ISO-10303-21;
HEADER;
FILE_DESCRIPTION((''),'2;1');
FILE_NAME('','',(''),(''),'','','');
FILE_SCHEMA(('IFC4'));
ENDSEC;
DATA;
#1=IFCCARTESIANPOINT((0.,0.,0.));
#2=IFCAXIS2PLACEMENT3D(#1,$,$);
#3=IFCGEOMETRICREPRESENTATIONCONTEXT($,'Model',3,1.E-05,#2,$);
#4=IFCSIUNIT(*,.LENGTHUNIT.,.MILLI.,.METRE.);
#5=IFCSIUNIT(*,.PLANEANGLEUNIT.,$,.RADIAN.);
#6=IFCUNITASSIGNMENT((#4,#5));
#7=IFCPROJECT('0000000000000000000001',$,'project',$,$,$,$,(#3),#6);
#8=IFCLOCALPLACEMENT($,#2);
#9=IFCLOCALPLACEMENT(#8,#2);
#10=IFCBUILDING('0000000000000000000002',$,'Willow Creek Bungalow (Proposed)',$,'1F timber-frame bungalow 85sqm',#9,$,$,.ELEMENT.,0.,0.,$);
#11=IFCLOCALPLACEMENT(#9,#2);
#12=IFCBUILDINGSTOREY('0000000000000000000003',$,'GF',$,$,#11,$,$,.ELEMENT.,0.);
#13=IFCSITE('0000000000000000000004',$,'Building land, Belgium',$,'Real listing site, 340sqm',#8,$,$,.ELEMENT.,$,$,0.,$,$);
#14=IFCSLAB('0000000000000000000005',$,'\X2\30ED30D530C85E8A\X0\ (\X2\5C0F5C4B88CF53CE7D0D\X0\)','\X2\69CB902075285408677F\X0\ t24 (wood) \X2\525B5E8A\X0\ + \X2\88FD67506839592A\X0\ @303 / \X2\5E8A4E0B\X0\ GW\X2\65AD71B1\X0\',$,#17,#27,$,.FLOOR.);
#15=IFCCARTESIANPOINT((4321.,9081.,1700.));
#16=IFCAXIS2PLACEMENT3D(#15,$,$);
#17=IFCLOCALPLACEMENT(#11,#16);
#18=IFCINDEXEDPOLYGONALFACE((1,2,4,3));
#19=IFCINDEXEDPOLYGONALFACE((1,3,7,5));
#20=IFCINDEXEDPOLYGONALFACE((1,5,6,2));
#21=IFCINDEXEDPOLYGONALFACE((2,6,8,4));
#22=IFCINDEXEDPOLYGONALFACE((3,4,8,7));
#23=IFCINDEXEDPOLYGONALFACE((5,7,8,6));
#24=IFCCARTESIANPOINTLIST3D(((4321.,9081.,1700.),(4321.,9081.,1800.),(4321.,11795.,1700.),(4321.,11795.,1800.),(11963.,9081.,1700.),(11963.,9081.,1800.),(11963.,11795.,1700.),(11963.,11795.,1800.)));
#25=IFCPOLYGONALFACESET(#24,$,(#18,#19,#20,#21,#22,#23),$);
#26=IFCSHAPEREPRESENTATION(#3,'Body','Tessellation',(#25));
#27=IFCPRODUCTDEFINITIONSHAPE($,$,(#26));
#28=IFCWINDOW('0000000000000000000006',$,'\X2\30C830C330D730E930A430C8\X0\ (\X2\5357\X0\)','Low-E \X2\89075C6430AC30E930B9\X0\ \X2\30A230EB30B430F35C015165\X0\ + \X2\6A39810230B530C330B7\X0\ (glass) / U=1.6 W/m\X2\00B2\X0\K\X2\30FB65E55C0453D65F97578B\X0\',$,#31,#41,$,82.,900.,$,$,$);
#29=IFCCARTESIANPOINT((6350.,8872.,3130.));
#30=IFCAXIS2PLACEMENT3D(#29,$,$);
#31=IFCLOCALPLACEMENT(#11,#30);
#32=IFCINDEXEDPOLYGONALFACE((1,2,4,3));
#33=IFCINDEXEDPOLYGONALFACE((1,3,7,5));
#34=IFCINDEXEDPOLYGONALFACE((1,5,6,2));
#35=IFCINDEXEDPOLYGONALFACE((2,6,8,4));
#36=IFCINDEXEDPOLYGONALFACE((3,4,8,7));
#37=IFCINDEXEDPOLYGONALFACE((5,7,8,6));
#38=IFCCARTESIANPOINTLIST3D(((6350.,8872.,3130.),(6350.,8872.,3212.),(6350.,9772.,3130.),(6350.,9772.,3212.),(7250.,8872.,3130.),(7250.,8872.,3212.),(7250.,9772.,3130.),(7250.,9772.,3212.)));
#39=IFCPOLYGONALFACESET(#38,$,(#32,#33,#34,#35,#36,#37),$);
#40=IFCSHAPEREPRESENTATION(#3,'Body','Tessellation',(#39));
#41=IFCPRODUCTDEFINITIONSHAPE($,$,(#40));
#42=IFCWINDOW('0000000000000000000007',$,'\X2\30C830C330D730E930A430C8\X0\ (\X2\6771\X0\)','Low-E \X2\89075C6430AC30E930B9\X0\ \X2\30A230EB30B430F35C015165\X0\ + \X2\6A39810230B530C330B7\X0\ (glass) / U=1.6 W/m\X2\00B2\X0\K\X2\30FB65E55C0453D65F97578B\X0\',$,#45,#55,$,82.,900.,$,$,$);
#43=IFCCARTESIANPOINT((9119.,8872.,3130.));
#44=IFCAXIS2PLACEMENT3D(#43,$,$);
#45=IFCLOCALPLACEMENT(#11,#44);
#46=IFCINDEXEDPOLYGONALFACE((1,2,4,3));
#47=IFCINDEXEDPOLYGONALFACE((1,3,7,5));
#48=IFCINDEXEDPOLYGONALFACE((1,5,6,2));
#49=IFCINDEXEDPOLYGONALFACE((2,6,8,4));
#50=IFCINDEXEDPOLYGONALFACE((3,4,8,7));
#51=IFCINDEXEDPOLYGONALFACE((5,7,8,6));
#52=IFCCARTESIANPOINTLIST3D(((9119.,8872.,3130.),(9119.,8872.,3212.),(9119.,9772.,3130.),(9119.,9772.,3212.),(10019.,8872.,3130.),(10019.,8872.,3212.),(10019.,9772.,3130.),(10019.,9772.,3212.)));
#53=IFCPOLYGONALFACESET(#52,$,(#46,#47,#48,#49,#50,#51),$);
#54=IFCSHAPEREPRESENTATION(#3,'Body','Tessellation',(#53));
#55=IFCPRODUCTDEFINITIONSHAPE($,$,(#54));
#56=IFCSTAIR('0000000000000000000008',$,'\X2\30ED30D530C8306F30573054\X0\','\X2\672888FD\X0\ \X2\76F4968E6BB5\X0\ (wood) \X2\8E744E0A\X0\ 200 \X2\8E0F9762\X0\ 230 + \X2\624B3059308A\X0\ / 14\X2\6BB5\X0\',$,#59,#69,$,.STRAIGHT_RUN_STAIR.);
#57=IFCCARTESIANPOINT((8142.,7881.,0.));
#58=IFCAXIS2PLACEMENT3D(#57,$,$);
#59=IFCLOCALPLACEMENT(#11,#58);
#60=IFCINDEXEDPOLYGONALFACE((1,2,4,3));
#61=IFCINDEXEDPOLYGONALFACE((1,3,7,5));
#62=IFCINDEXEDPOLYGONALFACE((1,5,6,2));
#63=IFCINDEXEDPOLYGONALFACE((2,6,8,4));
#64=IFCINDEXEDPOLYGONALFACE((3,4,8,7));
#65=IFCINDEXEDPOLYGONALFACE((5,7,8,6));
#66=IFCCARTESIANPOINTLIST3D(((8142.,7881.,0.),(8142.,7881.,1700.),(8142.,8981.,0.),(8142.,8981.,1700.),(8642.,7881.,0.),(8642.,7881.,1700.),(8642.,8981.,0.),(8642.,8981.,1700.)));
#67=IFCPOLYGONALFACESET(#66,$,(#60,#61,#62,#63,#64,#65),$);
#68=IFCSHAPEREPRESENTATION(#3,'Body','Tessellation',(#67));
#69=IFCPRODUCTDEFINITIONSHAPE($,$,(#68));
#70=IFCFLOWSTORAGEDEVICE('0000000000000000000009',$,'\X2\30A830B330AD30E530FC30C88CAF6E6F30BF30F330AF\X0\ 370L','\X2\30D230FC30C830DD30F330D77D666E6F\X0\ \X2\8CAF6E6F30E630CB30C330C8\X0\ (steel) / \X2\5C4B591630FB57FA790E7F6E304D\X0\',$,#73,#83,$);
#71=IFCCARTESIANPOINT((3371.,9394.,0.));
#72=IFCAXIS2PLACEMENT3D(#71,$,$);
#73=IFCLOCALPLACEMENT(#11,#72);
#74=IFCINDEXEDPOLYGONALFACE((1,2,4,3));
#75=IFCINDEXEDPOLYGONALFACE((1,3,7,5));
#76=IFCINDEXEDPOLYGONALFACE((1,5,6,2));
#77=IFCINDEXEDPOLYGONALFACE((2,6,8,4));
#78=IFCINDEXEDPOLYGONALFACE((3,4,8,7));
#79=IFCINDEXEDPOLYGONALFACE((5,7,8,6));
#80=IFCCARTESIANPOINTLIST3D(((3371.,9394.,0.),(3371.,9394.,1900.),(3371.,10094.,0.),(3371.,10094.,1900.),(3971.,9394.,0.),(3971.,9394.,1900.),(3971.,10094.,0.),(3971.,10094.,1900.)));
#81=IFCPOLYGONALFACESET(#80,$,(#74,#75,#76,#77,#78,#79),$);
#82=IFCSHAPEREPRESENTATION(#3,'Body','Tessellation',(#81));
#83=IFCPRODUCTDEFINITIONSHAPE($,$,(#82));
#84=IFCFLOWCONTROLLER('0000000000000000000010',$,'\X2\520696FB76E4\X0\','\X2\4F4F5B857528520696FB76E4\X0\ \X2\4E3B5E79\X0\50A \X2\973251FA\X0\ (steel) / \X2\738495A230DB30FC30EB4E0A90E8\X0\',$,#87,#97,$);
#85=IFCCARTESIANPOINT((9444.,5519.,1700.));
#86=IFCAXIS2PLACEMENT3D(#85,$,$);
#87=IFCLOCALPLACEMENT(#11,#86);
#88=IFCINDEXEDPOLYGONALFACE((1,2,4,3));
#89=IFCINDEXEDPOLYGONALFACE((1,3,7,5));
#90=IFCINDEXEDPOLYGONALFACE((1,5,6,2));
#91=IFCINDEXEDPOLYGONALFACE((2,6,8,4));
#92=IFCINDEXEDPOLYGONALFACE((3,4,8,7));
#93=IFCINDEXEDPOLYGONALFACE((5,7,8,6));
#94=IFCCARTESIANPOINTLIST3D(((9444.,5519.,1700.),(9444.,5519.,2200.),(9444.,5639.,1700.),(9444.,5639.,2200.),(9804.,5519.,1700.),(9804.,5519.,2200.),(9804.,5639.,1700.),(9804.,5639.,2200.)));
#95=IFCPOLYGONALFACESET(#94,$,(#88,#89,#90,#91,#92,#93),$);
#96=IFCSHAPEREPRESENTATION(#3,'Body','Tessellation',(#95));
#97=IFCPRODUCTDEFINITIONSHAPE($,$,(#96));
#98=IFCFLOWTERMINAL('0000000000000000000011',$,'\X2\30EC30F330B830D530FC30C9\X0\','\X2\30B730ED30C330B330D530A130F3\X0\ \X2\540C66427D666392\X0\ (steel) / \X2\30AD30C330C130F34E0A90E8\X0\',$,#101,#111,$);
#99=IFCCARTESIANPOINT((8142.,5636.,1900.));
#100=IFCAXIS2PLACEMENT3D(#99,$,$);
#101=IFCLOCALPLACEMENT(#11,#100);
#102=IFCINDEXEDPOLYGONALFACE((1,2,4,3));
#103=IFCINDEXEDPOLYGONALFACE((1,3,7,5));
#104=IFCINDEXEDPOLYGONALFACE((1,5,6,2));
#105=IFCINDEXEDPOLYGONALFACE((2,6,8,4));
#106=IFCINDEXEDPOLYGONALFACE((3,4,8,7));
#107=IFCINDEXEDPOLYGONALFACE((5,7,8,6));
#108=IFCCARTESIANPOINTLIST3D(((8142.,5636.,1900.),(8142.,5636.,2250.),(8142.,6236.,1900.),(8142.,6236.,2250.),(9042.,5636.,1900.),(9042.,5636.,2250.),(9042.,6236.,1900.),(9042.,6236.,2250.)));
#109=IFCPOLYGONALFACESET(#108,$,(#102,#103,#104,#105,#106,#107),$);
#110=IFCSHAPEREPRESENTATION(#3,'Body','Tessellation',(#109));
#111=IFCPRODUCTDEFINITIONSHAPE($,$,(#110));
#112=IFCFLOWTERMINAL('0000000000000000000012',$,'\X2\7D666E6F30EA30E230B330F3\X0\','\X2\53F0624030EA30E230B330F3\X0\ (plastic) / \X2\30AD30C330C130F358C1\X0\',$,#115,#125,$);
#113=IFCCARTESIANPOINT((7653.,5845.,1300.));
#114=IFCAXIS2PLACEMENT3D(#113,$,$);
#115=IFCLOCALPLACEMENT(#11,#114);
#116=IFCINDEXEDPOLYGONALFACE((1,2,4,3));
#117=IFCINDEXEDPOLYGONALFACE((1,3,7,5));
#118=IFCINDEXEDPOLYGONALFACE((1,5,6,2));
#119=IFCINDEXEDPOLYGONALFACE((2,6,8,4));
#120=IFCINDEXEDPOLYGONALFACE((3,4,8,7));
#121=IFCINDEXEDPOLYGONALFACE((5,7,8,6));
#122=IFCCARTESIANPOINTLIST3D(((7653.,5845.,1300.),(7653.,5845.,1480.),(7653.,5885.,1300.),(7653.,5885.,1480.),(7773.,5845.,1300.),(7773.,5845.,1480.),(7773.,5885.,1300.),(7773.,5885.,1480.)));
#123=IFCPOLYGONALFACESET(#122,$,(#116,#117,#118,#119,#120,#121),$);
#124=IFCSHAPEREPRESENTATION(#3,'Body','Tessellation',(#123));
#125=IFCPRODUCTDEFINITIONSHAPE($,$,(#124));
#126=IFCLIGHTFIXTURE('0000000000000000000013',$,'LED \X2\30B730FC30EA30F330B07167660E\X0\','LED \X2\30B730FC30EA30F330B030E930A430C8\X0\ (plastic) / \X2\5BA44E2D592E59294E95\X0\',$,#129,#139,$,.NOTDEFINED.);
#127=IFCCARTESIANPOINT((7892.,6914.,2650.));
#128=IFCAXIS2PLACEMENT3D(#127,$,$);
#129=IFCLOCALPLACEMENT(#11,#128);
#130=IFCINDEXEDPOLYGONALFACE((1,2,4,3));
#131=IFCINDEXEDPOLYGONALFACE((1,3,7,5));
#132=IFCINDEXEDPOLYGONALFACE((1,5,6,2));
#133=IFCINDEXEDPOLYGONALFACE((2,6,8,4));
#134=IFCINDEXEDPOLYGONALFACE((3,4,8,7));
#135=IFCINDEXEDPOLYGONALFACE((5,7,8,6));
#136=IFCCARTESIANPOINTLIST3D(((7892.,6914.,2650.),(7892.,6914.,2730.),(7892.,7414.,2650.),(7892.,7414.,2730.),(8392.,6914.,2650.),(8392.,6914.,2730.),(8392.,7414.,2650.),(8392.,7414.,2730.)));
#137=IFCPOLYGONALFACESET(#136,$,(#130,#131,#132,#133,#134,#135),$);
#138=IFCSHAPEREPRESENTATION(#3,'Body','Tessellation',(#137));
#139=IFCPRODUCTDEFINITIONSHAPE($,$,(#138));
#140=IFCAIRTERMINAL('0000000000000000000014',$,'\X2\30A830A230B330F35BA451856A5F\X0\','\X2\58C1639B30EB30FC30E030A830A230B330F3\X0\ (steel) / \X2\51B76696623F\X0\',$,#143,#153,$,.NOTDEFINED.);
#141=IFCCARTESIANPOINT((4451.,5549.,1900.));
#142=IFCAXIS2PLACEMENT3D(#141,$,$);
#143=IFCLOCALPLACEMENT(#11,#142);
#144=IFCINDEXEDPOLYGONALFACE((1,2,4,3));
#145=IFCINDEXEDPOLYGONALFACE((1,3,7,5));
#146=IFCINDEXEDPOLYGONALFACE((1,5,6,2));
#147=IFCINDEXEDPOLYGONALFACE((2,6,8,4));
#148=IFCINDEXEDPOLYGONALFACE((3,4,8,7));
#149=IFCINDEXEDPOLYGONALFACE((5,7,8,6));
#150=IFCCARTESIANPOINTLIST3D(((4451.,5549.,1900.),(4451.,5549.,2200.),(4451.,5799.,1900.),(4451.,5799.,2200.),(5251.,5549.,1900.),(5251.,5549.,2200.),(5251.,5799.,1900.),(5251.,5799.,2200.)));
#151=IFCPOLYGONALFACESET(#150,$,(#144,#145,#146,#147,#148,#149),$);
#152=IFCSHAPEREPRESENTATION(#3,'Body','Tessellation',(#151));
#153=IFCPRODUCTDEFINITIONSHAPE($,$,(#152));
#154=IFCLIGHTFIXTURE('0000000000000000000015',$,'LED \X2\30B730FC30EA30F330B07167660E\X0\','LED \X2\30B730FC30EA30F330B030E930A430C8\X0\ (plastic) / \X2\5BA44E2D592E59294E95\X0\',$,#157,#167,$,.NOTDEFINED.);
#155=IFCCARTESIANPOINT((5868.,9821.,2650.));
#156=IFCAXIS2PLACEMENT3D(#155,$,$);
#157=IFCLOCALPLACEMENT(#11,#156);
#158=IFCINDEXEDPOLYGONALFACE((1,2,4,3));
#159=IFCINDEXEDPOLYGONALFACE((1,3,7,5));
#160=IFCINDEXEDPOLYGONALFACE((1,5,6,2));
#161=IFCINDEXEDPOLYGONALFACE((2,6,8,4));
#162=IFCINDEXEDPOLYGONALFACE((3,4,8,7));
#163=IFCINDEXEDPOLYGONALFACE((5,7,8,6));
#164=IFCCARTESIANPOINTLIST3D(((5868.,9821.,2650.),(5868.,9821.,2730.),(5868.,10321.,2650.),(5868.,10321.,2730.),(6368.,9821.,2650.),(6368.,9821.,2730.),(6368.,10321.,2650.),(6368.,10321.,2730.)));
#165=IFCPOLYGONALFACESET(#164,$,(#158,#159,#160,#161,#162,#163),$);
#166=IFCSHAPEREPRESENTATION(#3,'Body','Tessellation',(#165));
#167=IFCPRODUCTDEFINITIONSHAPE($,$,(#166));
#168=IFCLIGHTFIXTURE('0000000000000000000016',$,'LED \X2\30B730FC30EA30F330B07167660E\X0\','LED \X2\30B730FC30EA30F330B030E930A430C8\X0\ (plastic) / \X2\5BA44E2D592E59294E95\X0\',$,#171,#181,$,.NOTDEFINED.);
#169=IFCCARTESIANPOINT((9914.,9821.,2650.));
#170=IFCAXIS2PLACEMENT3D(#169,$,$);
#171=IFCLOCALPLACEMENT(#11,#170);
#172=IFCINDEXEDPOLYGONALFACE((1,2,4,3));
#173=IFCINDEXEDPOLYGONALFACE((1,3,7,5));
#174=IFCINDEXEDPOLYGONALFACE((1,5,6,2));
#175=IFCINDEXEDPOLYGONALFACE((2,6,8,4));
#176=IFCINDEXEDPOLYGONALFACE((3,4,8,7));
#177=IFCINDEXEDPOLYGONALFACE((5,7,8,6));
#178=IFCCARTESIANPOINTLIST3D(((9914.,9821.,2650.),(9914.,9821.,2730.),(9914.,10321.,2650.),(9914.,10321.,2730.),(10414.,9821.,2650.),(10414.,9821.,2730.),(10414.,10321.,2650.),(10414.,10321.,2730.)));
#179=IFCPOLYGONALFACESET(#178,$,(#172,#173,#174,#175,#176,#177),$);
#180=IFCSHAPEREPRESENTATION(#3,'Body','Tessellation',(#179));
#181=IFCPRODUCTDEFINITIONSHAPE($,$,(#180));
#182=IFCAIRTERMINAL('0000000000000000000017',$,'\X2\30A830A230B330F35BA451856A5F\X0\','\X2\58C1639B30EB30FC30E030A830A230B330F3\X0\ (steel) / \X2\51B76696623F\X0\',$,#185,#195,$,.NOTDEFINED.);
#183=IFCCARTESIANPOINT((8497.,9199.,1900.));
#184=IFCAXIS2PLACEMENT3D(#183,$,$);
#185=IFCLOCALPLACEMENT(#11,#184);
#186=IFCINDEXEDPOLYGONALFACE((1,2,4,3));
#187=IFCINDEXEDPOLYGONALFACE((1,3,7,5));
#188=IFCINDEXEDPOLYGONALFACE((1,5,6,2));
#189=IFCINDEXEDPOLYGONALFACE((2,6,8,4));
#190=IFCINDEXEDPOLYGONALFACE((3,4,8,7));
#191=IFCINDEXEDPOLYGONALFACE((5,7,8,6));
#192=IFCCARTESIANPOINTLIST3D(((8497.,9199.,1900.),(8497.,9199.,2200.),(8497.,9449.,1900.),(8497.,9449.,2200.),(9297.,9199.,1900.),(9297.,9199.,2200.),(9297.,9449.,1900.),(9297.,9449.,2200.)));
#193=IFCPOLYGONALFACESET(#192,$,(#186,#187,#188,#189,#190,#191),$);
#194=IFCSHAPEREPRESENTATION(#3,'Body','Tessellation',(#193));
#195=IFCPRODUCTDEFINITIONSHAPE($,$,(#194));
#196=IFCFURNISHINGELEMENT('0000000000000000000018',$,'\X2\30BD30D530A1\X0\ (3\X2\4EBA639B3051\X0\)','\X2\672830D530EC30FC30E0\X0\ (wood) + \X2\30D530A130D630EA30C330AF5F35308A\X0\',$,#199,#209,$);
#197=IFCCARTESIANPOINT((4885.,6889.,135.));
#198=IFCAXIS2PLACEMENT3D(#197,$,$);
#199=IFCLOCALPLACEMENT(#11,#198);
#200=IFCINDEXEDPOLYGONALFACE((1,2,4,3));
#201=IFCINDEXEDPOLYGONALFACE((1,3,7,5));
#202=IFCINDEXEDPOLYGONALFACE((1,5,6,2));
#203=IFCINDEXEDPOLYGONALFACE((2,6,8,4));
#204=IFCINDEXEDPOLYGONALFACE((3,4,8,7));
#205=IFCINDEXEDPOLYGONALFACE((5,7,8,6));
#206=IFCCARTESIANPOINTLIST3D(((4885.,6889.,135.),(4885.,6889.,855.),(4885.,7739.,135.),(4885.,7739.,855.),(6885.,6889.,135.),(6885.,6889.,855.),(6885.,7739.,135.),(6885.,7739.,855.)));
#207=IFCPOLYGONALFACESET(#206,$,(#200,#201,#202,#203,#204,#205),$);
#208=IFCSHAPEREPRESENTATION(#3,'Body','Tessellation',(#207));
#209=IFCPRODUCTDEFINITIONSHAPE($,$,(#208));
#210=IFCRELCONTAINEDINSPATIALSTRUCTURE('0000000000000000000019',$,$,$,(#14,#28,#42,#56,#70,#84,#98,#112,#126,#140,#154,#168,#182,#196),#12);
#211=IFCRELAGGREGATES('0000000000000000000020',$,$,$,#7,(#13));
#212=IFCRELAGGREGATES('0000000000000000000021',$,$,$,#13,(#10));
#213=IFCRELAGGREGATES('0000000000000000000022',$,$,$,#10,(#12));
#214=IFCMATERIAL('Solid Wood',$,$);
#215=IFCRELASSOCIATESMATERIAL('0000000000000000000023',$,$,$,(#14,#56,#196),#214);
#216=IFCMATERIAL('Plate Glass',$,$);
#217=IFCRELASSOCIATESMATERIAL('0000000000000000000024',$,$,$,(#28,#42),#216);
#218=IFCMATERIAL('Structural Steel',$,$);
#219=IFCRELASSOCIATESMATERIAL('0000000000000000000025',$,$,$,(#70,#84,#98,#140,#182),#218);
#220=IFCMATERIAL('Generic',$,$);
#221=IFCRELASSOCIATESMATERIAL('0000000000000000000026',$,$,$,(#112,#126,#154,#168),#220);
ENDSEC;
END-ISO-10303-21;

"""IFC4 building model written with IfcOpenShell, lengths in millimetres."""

from ifc_helpers import new_model, si_unit, frame, frame_2d, origin, place, context, project, spatial, rectangle, extrude, material, element, save


model = new_model("IFC4")

# Units and contexts
model_context = context("Model", 3, precision=1e-05, world=origin())
ifc_project = project(units=[si_unit("LENGTHUNIT", "METRE", prefix="MILLI"), si_unit("PLANEANGLEUNIT", "RADIAN")], contexts=[model_context])

# Site, building, storey
site_placement = place(None, origin())
site = spatial("IfcSite", under=ifc_project, at=site_placement, Name="Building land, Belgium", ObjectType="Real listing site, 340sqm", CompositionType="ELEMENT", RefElevation=0.0)
building_placement = place(site_placement, origin())
building = spatial("IfcBuilding", under=site, at=building_placement, Name="Willow Creek Bungalow (Proposed)", ObjectType="1F timber-frame bungalow 85sqm", CompositionType="ELEMENT", ElevationOfRefHeight=0.0, ElevationOfTerrain=0.0)
storey_placement = place(building_placement, origin())
storey = spatial("IfcBuildingStorey", under=building, at=storey_placement, Name="GF", CompositionType="ELEMENT", Elevation=0.0)

# Shared definitions
ifc_material_1 = material(Name="Solid Wood")

# Slab
slab_placement = place(storey_placement, frame((4321.0, 9081.0, 1700.0)))
element("IfcSlab", 1, at=slab_placement, inside=storey, material=ifc_material_1, Name="ロフト床 (小屋裏収納)", Description="構造用合板 t24 (wood) 剛床 + 製材根太 @303 / 床下 GW断熱", PredefinedType="FLOOR", context=model_context, shape_type="SweptSolid", body=[
    extrude(rectangle(XDim=7642.0, YDim=2714.0, at=frame_2d((3821.0, 1357.0))), frame((4321.0, 9081.0, 1700.0)), (0.0, 0.0, 1.0), 100.0),
])

# Windows
ifc_material_2 = material(Name="Plate Glass")
window_1_placement = place(storey_placement, frame((6350.0, 8872.0, 3130.0)))
element("IfcWindow", 2, at=window_1_placement, inside=storey, material=ifc_material_2, Name="トップライト (南)", Description="Low-E 複層ガラス アルゴン封入 + 樹脂サッシ (glass) / U=1.6 W/m²K・日射取得型", OverallHeight=82.0, OverallWidth=900.0, context=model_context, shape_type="SweptSolid", body=[
    extrude(rectangle(XDim=900.0, YDim=900.0, at=frame_2d((450.0, 450.0))), frame((6350.0, 8872.0, 3130.0)), (0.0, 0.0, 1.0), 82.0),
])
window_2_placement = place(storey_placement, frame((9119.0, 8872.0, 3130.0)))
element("IfcWindow", 3, at=window_2_placement, inside=storey, material=ifc_material_2, Name="トップライト (東)", Description="Low-E 複層ガラス アルゴン封入 + 樹脂サッシ (glass) / U=1.6 W/m²K・日射取得型", OverallHeight=82.0, OverallWidth=900.0, context=model_context, shape_type="SweptSolid", body=[
    extrude(rectangle(XDim=900.0, YDim=900.0, at=frame_2d((450.0, 450.0))), frame((9119.0, 8872.0, 3130.0)), (0.0, 0.0, 1.0), 82.0),
])

# Stair
stair_placement = place(storey_placement, frame((8142.0, 7881.0, 0.0)))
element("IfcStair", 4, at=stair_placement, inside=storey, material=ifc_material_1, Name="ロフトはしご", Description="木製 直階段 (wood) 蹴上 200 踏面 230 + 手すり / 14段", PredefinedType="STRAIGHT_RUN_STAIR", context=model_context, shape_type="SweptSolid", body=[
    extrude(rectangle(XDim=500.0, YDim=1100.0, at=frame_2d((250.0, 550.0))), frame((8142.0, 7881.0, 0.0)), (0.0, 0.0, 1.0), 1700.0),
])

# Flow storage device
ifc_material_3 = material(Name="Structural Steel")
flow_storage_device_placement = place(storey_placement, frame((3371.0, 9394.0, 0.0)))
element("IfcFlowStorageDevice", 5, at=flow_storage_device_placement, inside=storey, material=ifc_material_3, Name="エコキュート貯湯タンク 370L", Description="ヒートポンプ給湯 貯湯ユニット (steel) / 屋外・基礎置き", context=model_context, shape_type="SweptSolid", body=[
    extrude(rectangle(XDim=600.0, YDim=700.0, at=frame_2d((300.0, 350.0))), frame((3371.0, 9394.0, 0.0)), (0.0, 0.0, 1.0), 1900.0),
])

# Flow controller
flow_controller_placement = place(storey_placement, frame((9444.0, 5519.0, 1700.0)))
element("IfcFlowController", 6, at=flow_controller_placement, inside=storey, material=ifc_material_3, Name="分電盤", Description="住宅用分電盤 主幹50A 露出 (steel) / 玄関ホール上部", context=model_context, shape_type="SweptSolid", body=[
    extrude(rectangle(XDim=360.0, YDim=120.0, at=frame_2d((180.0, 60.0))), frame((9444.0, 5519.0, 1700.0)), (0.0, 0.0, 1.0), 500.0),
])

# Flow terminals
flow_terminal_1_placement = place(storey_placement, frame((8142.0, 5636.0, 1900.0)))
element("IfcFlowTerminal", 7, at=flow_terminal_1_placement, inside=storey, material=ifc_material_3, Name="レンジフード", Description="シロッコファン 同時給排 (steel) / キッチン上部", context=model_context, shape_type="SweptSolid", body=[
    extrude(rectangle(XDim=900.0, YDim=600.0, at=frame_2d((450.0, 300.0))), frame((8142.0, 5636.0, 1900.0)), (0.0, 0.0, 1.0), 350.0),
])
ifc_material_4 = material(Name="Generic")
flow_terminal_2_placement = place(storey_placement, frame((7653.0, 5845.0, 1300.0)))
element("IfcFlowTerminal", 8, at=flow_terminal_2_placement, inside=storey, material=ifc_material_4, Name="給湯リモコン", Description="台所リモコン (plastic) / キッチン壁", context=model_context, shape_type="SweptSolid", body=[
    extrude(rectangle(XDim=120.0, YDim=40.0, at=frame_2d((60.0, 20.0))), frame((7653.0, 5845.0, 1300.0)), (0.0, 0.0, 1.0), 180.0),
])

# Light fixture
light_fixture_1_placement = place(storey_placement, frame((7892.0, 6914.0, 2650.0)))
element("IfcLightFixture", 9, at=light_fixture_1_placement, inside=storey, material=ifc_material_4, Name="LED シーリング照明", Description="LED シーリングライト (plastic) / 室中央天井", PredefinedType="NOTDEFINED", context=model_context, shape_type="SweptSolid", body=[
    extrude(rectangle(XDim=500.0, YDim=500.0, at=frame_2d((250.0, 250.0))), frame((7892.0, 6914.0, 2650.0)), (0.0, 0.0, 1.0), 80.0),
])

# Air terminal
air_terminal_1_placement = place(storey_placement, frame((4451.0, 5549.0, 1900.0)))
element("IfcAirTerminal", 10, at=air_terminal_1_placement, inside=storey, material=ifc_material_3, Name="エアコン室内機", Description="壁掛ルームエアコン (steel) / 冷暖房", PredefinedType="NOTDEFINED", context=model_context, shape_type="SweptSolid", body=[
    extrude(rectangle(XDim=800.0, YDim=250.0, at=frame_2d((400.0, 125.0))), frame((4451.0, 5549.0, 1900.0)), (0.0, 0.0, 1.0), 300.0),
])

# Light fixtures
light_fixture_2_placement = place(storey_placement, frame((5868.0, 9821.0, 2650.0)))
element("IfcLightFixture", 11, at=light_fixture_2_placement, inside=storey, material=ifc_material_4, Name="LED シーリング照明", Description="LED シーリングライト (plastic) / 室中央天井", PredefinedType="NOTDEFINED", context=model_context, shape_type="SweptSolid", body=[
    extrude(rectangle(XDim=500.0, YDim=500.0, at=frame_2d((250.0, 250.0))), frame((5868.0, 9821.0, 2650.0)), (0.0, 0.0, 1.0), 80.0),
])
light_fixture_3_placement = place(storey_placement, frame((9914.0, 9821.0, 2650.0)))
element("IfcLightFixture", 12, at=light_fixture_3_placement, inside=storey, material=ifc_material_4, Name="LED シーリング照明", Description="LED シーリングライト (plastic) / 室中央天井", PredefinedType="NOTDEFINED", context=model_context, shape_type="SweptSolid", body=[
    extrude(rectangle(XDim=500.0, YDim=500.0, at=frame_2d((250.0, 250.0))), frame((9914.0, 9821.0, 2650.0)), (0.0, 0.0, 1.0), 80.0),
])

# Air terminal
air_terminal_2_placement = place(storey_placement, frame((8497.0, 9199.0, 1900.0)))
element("IfcAirTerminal", 13, at=air_terminal_2_placement, inside=storey, material=ifc_material_3, Name="エアコン室内機", Description="壁掛ルームエアコン (steel) / 冷暖房", PredefinedType="NOTDEFINED", context=model_context, shape_type="SweptSolid", body=[
    extrude(rectangle(XDim=800.0, YDim=250.0, at=frame_2d((400.0, 125.0))), frame((8497.0, 9199.0, 1900.0)), (0.0, 0.0, 1.0), 300.0),
])

# Furnishing element
furnishing_1_placement = place(storey_placement, frame((4885.0, 6889.0, 135.0)))
element("IfcFurnishingElement", 14, at=furnishing_1_placement, inside=storey, material=ifc_material_1, Name="ソファ (3人掛け)", Description="木フレーム (wood) + ファブリック張り", context=model_context, shape_type="SweptSolid", body=[
    extrude(rectangle(XDim=2000.0, YDim=850.0, at=frame_2d((1000.0, 425.0))), frame((4885.0, 6889.0, 135.0)), (0.0, 0.0, 1.0), 720.0),
])

save(model, "model.ifc")
